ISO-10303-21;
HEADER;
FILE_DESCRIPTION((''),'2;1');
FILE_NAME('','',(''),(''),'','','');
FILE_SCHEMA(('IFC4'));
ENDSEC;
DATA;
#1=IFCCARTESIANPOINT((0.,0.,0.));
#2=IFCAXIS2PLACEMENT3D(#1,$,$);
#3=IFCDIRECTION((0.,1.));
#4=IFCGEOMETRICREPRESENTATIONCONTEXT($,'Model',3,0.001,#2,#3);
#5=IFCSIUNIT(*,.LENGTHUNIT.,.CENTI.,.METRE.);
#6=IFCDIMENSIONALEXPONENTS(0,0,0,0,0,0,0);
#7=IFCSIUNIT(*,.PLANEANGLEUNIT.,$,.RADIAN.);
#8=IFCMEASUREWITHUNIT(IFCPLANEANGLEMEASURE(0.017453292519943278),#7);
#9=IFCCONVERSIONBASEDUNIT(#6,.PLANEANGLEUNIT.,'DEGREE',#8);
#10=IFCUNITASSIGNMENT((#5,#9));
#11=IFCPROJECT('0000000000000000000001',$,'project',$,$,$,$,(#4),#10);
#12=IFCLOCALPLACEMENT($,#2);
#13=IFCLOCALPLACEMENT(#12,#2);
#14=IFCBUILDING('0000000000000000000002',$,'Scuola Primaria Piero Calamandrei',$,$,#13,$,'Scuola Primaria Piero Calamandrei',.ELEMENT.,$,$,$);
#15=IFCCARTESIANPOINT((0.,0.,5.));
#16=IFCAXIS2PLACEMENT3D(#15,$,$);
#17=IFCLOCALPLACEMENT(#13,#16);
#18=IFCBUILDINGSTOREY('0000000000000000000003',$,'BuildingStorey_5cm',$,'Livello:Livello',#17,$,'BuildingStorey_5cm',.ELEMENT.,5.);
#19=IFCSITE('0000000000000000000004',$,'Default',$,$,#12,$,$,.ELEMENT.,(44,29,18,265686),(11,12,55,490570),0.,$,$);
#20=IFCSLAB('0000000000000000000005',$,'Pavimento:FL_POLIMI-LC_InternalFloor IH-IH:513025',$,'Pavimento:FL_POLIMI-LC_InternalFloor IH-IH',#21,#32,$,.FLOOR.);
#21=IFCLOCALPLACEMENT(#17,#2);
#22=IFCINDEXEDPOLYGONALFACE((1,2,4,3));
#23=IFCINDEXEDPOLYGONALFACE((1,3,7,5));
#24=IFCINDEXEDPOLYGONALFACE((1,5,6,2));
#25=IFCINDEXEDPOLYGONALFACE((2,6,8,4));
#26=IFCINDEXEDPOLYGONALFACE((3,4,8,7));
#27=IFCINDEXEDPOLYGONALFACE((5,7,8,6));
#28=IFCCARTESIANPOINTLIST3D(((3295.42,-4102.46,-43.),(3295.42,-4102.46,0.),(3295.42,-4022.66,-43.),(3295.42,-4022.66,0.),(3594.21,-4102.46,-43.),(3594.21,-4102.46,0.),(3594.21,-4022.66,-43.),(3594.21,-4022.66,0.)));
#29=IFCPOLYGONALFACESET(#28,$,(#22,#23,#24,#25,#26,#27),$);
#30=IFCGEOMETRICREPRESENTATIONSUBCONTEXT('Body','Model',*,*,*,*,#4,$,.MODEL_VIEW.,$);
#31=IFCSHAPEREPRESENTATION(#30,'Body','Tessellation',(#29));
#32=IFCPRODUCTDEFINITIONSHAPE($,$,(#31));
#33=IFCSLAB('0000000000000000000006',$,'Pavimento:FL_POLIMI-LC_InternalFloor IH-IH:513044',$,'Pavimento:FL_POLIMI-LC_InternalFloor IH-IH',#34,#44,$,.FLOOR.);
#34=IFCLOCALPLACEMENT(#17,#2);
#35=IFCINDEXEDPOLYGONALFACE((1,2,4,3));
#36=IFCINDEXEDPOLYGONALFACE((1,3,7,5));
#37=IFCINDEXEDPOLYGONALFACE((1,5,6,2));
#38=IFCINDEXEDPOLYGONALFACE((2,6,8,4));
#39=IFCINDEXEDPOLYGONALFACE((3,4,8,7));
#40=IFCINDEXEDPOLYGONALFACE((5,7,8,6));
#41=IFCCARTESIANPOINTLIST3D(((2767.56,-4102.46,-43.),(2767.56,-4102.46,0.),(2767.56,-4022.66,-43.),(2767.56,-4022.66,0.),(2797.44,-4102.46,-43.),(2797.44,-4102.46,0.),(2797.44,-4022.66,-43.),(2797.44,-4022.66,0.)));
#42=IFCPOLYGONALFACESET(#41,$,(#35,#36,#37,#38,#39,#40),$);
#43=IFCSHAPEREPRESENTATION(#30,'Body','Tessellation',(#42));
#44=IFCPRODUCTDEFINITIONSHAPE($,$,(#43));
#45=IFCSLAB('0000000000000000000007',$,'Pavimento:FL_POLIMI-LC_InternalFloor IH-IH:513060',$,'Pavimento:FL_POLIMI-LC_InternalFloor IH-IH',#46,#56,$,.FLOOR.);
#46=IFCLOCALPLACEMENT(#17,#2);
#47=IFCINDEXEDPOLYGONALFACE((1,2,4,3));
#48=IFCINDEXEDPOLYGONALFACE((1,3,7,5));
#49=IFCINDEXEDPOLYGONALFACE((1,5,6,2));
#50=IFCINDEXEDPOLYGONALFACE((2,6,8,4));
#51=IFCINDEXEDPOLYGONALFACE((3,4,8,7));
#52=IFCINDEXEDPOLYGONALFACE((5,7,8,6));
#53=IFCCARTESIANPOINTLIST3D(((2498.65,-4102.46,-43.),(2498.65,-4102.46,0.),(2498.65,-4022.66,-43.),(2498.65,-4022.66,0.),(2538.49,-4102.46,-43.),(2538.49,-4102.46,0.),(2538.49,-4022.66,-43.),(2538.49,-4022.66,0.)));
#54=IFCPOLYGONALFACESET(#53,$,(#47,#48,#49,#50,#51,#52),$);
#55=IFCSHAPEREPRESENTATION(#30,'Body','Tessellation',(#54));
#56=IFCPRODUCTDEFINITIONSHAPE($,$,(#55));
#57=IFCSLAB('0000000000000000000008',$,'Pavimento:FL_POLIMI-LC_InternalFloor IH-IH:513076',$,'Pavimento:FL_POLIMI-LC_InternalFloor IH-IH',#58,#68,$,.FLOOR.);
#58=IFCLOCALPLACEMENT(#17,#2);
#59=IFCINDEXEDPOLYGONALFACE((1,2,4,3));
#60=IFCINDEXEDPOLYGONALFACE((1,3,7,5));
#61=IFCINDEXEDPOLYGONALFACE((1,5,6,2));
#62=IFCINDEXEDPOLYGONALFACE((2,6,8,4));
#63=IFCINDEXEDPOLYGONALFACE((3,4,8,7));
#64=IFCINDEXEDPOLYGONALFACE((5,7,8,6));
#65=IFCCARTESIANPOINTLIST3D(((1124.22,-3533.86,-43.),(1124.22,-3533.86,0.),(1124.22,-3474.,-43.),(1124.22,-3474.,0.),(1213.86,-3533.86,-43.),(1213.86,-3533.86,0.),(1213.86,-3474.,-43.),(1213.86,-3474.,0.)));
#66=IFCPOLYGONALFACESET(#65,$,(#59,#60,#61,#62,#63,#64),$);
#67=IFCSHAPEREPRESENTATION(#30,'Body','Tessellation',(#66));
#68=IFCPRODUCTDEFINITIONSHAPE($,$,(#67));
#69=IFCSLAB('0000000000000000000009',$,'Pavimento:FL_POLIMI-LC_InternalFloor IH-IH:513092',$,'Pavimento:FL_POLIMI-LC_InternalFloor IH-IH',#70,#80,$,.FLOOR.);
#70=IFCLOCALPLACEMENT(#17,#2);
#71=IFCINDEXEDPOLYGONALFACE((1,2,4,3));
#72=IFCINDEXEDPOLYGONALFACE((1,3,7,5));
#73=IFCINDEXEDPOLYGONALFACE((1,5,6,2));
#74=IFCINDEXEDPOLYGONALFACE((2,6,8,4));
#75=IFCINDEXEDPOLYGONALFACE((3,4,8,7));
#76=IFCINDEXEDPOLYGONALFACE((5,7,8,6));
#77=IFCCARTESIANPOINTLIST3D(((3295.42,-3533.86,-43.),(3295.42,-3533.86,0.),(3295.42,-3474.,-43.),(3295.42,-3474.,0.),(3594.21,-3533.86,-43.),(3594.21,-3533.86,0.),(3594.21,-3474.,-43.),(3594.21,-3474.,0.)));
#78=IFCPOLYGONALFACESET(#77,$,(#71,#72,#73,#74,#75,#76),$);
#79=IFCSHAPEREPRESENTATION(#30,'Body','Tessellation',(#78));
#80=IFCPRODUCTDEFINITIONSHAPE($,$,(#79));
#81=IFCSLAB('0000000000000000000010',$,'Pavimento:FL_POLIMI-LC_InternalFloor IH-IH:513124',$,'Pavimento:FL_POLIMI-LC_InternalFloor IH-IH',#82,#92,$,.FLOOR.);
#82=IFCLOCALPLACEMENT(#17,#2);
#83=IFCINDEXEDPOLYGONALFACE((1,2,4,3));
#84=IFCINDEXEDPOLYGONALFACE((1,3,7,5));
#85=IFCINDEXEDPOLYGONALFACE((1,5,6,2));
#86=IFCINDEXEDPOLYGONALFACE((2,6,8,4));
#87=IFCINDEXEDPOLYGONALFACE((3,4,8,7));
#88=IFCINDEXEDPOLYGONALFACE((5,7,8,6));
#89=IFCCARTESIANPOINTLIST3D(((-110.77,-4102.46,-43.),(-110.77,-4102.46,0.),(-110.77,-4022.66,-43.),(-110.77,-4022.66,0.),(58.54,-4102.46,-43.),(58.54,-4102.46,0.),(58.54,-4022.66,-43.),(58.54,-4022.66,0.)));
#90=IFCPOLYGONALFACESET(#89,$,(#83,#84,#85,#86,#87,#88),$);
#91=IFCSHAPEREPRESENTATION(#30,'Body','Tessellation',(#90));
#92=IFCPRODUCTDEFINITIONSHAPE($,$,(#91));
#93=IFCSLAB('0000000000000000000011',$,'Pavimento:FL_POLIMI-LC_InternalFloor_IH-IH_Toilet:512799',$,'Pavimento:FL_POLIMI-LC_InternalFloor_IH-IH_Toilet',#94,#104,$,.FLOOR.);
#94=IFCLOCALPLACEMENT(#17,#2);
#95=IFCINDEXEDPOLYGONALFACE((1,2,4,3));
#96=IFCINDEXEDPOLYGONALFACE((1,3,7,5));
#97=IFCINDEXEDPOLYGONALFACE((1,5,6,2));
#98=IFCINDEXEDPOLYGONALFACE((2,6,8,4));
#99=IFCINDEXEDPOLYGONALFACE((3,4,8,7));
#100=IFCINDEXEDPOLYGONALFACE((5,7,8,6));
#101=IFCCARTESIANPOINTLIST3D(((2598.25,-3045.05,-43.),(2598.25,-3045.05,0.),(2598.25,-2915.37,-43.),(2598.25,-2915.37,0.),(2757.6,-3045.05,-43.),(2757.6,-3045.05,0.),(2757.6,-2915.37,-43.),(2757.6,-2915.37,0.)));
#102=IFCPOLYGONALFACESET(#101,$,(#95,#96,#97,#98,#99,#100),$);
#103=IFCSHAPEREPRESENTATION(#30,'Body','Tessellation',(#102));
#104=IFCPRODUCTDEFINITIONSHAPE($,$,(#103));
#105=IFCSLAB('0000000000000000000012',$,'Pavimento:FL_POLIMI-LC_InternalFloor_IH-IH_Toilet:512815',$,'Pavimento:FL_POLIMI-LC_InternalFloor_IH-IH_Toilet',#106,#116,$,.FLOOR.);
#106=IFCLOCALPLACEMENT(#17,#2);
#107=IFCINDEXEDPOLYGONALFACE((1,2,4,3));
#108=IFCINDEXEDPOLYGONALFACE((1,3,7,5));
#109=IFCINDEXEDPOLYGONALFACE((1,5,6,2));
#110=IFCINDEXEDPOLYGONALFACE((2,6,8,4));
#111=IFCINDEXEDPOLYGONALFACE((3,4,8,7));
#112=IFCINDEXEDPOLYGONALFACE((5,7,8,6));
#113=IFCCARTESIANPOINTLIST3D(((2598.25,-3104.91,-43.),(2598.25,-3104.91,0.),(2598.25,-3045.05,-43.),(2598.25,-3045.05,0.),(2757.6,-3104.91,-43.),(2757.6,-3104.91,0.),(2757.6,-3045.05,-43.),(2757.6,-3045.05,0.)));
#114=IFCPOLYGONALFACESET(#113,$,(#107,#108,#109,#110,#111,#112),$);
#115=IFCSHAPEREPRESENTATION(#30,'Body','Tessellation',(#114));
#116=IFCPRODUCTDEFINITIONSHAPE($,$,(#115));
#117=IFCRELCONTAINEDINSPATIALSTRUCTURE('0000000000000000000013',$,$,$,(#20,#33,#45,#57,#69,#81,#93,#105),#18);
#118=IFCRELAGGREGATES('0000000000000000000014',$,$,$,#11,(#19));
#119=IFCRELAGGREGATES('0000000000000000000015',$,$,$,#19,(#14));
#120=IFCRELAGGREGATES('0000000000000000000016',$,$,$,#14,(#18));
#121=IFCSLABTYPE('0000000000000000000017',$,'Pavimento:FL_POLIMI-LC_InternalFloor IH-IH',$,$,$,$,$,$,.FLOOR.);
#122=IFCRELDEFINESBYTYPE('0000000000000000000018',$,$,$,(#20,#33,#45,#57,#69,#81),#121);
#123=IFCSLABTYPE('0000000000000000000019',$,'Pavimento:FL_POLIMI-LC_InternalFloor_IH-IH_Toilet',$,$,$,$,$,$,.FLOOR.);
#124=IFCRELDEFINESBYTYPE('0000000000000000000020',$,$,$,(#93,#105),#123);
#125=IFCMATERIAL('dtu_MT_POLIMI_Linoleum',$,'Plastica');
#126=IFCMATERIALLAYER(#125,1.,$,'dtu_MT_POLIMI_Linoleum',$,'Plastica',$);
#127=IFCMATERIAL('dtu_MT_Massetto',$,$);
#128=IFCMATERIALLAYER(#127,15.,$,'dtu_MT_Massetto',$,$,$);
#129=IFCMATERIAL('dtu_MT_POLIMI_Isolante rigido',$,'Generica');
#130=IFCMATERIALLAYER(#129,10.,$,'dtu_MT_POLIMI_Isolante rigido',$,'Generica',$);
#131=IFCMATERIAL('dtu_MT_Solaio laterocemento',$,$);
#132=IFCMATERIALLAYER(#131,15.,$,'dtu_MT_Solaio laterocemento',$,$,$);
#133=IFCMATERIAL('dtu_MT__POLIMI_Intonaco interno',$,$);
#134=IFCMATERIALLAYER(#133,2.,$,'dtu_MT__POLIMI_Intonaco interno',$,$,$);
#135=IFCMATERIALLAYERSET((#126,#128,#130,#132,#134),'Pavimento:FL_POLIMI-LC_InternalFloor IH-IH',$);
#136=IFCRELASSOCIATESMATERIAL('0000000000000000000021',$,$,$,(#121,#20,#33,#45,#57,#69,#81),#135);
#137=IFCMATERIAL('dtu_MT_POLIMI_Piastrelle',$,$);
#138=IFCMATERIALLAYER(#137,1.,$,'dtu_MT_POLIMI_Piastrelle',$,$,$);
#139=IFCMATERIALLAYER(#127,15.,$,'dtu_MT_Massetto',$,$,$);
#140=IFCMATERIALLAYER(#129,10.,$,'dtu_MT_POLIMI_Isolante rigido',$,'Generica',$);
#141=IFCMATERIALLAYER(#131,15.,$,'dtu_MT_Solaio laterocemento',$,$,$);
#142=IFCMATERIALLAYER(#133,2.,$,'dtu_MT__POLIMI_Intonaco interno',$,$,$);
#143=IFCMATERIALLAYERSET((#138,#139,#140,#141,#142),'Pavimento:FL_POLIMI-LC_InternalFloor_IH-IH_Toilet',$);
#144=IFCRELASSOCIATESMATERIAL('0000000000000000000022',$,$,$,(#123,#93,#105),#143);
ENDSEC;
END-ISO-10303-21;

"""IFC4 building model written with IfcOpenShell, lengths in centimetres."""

from ifc_helpers import new_model, entity, si_unit, converted_unit, direction, frame, frame_2d, origin, place, context, subcontext, project, spatial, rectangle, extrude, material, layer, layer_set, layer_usage, type_object, element, save


model = new_model("IFC4")

# Units and contexts
model_context = context("Model", 3, precision=0.001, world=origin(), true_north=direction((0.0, 1.0)))
body_context = subcontext(model_context, "Body", "Model", "MODEL_VIEW")
ifc_project = project(units=[si_unit("LENGTHUNIT", "METRE", prefix="CENTI"), converted_unit("PLANEANGLEUNIT", "DEGREE", entity("IfcPlaneAngleMeasure", 0.017453292519943278), si_unit("PLANEANGLEUNIT", "RADIAN"), dimensions=[0, 0, 0, 0, 0, 0, 0])], contexts=[model_context])

# Site, building, storey
site_placement = place(None, origin())
site = spatial("IfcSite", under=ifc_project, at=site_placement, Name="Default", CompositionType="ELEMENT", RefLatitude=(44, 29, 18, 265686), RefLongitude=(11, 12, 55, 490570), RefElevation=0.0)
building_placement = place(site_placement, origin())
building = spatial("IfcBuilding", under=site, at=building_placement, Name="Scuola Primaria Piero Calamandrei", LongName="Scuola Primaria Piero Calamandrei", CompositionType="ELEMENT")
storey_placement = place(building_placement, frame((0.0, 0.0, 5.0)))
storey = spatial("IfcBuildingStorey", under=building, at=storey_placement, Name="BuildingStorey_5cm", ObjectType="Livello:Livello", LongName="BuildingStorey_5cm", CompositionType="ELEMENT", Elevation=5.0)

# Slabs
ifc_material_1 = material(Name="dtu_MT_POLIMI_Linoleum", Category="Plastica")
ifc_layer_1 = layer(ifc_material_1, 1.0, Name="dtu_MT_POLIMI_Linoleum", Category="Plastica")
ifc_material_2 = material(Name="dtu_MT_Massetto")
ifc_layer_2 = layer(ifc_material_2, 15.0, Name="dtu_MT_Massetto")
ifc_material_3 = material(Name="dtu_MT_POLIMI_Isolante rigido", Category="Generica")
ifc_layer_3 = layer(ifc_material_3, 10.0, Name="dtu_MT_POLIMI_Isolante rigido", Category="Generica")
ifc_material_4 = material(Name="dtu_MT_Solaio laterocemento")
ifc_layer_4 = layer(ifc_material_4, 15.0, Name="dtu_MT_Solaio laterocemento")
ifc_material_5 = material(Name="dtu_MT__POLIMI_Intonaco interno")
ifc_layer_5 = layer(ifc_material_5, 2.0, Name="dtu_MT__POLIMI_Intonaco interno")
ifc_layer_set_1 = layer_set([ifc_layer_1, ifc_layer_2, ifc_layer_3, ifc_layer_4, ifc_layer_5], Name="Pavimento:FL_POLIMI-LC_InternalFloor IH-IH")
slab_type_1 = type_object("IfcSlabType", Name="Pavimento:FL_POLIMI-LC_InternalFloor IH-IH", PredefinedType="FLOOR", material=ifc_layer_set_1)
ifc_layer_usage_1 = layer_usage(ifc_layer_set_1, "AXIS3", "POSITIVE", 0.0)
slab_1_placement = place(storey_placement, origin())
element("IfcSlab", 1, at=slab_1_placement, inside=storey, type_object=slab_type_1, material=ifc_layer_usage_1, Name="Pavimento:FL_POLIMI-LC_InternalFloor IH-IH:513025", ObjectType="Pavimento:FL_POLIMI-LC_InternalFloor IH-IH", PredefinedType="FLOOR", context=body_context, shape_type="SweptSolid", body=[
    extrude(rectangle(XDim=79.8, YDim=298.79, at=frame_2d((0.0, 0.0), x_axis=(1.0, 0.0))), frame((3444.81, -4062.56, 0.0), z_axis=(0.0, 0.0, -1.0), x_axis=(0.0, 1.0, 0.0)), (0.0, 0.0, 1.0), 43.0),
])
ifc_layer_usage_2 = layer_usage(ifc_layer_set_1, "AXIS3", "POSITIVE", 0.0)
slab_2_placement = place(storey_placement, origin())
element("IfcSlab", 2, at=slab_2_placement, inside=storey, type_object=slab_type_1, material=ifc_layer_usage_2, Name="Pavimento:FL_POLIMI-LC_InternalFloor IH-IH:513044", ObjectType="Pavimento:FL_POLIMI-LC_InternalFloor IH-IH", PredefinedType="FLOOR", context=body_context, shape_type="SweptSolid", body=[
    extrude(rectangle(XDim=79.8, YDim=29.88, at=frame_2d((0.0, 0.0), x_axis=(1.0, 0.0))), frame((2782.5, -4062.56, 0.0), z_axis=(0.0, 0.0, -1.0), x_axis=(0.0, 1.0, 0.0)), (0.0, 0.0, 1.0), 43.0),
])
ifc_layer_usage_3 = layer_usage(ifc_layer_set_1, "AXIS3", "POSITIVE", 0.0)
slab_3_placement = place(storey_placement, origin())
element("IfcSlab", 3, at=slab_3_placement, inside=storey, type_object=slab_type_1, material=ifc_layer_usage_3, Name="Pavimento:FL_POLIMI-LC_InternalFloor IH-IH:513060", ObjectType="Pavimento:FL_POLIMI-LC_InternalFloor IH-IH", PredefinedType="FLOOR", context=body_context, shape_type="SweptSolid", body=[
    extrude(rectangle(XDim=79.8, YDim=39.84, at=frame_2d((0.0, 0.0), x_axis=(1.0, 0.0))), frame((2518.57, -4062.56, 0.0), z_axis=(0.0, 0.0, -1.0), x_axis=(0.0, 1.0, 0.0)), (0.0, 0.0, 1.0), 43.0),
])
ifc_layer_usage_4 = layer_usage(ifc_layer_set_1, "AXIS3", "POSITIVE", 0.0)
slab_4_placement = place(storey_placement, origin())
element("IfcSlab", 4, at=slab_4_placement, inside=storey, type_object=slab_type_1, material=ifc_layer_usage_4, Name="Pavimento:FL_POLIMI-LC_InternalFloor IH-IH:513076", ObjectType="Pavimento:FL_POLIMI-LC_InternalFloor IH-IH", PredefinedType="FLOOR", context=body_context, shape_type="SweptSolid", body=[
    extrude(rectangle(XDim=59.85, YDim=89.64, at=frame_2d((0.0, 0.0), x_axis=(1.0, 0.0))), frame((1169.04, -3503.93, 0.0), z_axis=(0.0, 0.0, -1.0), x_axis=(0.0, 1.0, 0.0)), (0.0, 0.0, 1.0), 43.0),
])
ifc_layer_usage_5 = layer_usage(ifc_layer_set_1, "AXIS3", "POSITIVE", 0.0)
slab_5_placement = place(storey_placement, origin())
element("IfcSlab", 5, at=slab_5_placement, inside=storey, type_object=slab_type_1, material=ifc_layer_usage_5, Name="Pavimento:FL_POLIMI-LC_InternalFloor IH-IH:513092", ObjectType="Pavimento:FL_POLIMI-LC_InternalFloor IH-IH", PredefinedType="FLOOR", context=body_context, shape_type="SweptSolid", body=[
    extrude(rectangle(XDim=59.85, YDim=298.79, at=frame_2d((0.0, 0.0), x_axis=(1.0, 0.0))), frame((3444.81, -3503.93, 0.0), z_axis=(0.0, 0.0, -1.0), x_axis=(0.0, 1.0, 0.0)), (0.0, 0.0, 1.0), 43.0),
])
ifc_layer_usage_6 = layer_usage(ifc_layer_set_1, "AXIS3", "POSITIVE", 0.0)
slab_6_placement = place(storey_placement, origin())
element("IfcSlab", 6, at=slab_6_placement, inside=storey, type_object=slab_type_1, material=ifc_layer_usage_6, Name="Pavimento:FL_POLIMI-LC_InternalFloor IH-IH:513124", ObjectType="Pavimento:FL_POLIMI-LC_InternalFloor IH-IH", PredefinedType="FLOOR", context=body_context, shape_type="SweptSolid", body=[
    extrude(rectangle(XDim=79.8, YDim=169.31, at=frame_2d((0.0, 0.0), x_axis=(1.0, 0.0))), frame((-26.11, -4062.56, 0.0), z_axis=(0.0, 0.0, -1.0), x_axis=(0.0, -1.0, 0.0)), (0.0, 0.0, 1.0), 43.0),
])
ifc_material_6 = material(Name="dtu_MT_POLIMI_Piastrelle")
ifc_layer_6 = layer(ifc_material_6, 1.0, Name="dtu_MT_POLIMI_Piastrelle")
ifc_layer_7 = layer(ifc_material_2, 15.0, Name="dtu_MT_Massetto")
ifc_layer_8 = layer(ifc_material_3, 10.0, Name="dtu_MT_POLIMI_Isolante rigido", Category="Generica")
ifc_layer_9 = layer(ifc_material_4, 15.0, Name="dtu_MT_Solaio laterocemento")
ifc_layer_10 = layer(ifc_material_5, 2.0, Name="dtu_MT__POLIMI_Intonaco interno")
ifc_layer_set_2 = layer_set([ifc_layer_6, ifc_layer_7, ifc_layer_8, ifc_layer_9, ifc_layer_10], Name="Pavimento:FL_POLIMI-LC_InternalFloor_IH-IH_Toilet")
ifc_layer_usage_7 = layer_usage(ifc_layer_set_2, "AXIS3", "POSITIVE", 0.0)
slab_type_2 = type_object("IfcSlabType", Name="Pavimento:FL_POLIMI-LC_InternalFloor_IH-IH_Toilet", PredefinedType="FLOOR", material=ifc_layer_set_2)
slab_7_placement = place(storey_placement, origin())
element("IfcSlab", 7, at=slab_7_placement, inside=storey, type_object=slab_type_2, material=ifc_layer_usage_7, Name="Pavimento:FL_POLIMI-LC_InternalFloor_IH-IH_Toilet:512799", ObjectType="Pavimento:FL_POLIMI-LC_InternalFloor_IH-IH_Toilet", PredefinedType="FLOOR", context=body_context, shape_type="SweptSolid", body=[
    extrude(rectangle(XDim=129.68, YDim=159.35, at=frame_2d((0.0, 0.0), x_axis=(1.0, 0.0))), frame((2677.92, -2980.21, 0.0), z_axis=(0.0, 0.0, -1.0), x_axis=(0.0, 1.0, 0.0)), (0.0, 0.0, 1.0), 43.0),
])
ifc_layer_usage_8 = layer_usage(ifc_layer_set_2, "AXIS3", "POSITIVE", 0.0)
slab_8_placement = place(storey_placement, origin())
element("IfcSlab", 8, at=slab_8_placement, inside=storey, type_object=slab_type_2, material=ifc_layer_usage_8, Name="Pavimento:FL_POLIMI-LC_InternalFloor_IH-IH_Toilet:512815", ObjectType="Pavimento:FL_POLIMI-LC_InternalFloor_IH-IH_Toilet", PredefinedType="FLOOR", context=body_context, shape_type="SweptSolid", body=[
    extrude(rectangle(XDim=59.85, YDim=159.35, at=frame_2d((0.0, 0.0), x_axis=(1.0, 0.0))), frame((2677.92, -3074.98, 0.0), z_axis=(0.0, 0.0, -1.0), x_axis=(0.0, 1.0, 0.0)), (0.0, 0.0, 1.0), 43.0),
])

save(model, "model.ifc")
